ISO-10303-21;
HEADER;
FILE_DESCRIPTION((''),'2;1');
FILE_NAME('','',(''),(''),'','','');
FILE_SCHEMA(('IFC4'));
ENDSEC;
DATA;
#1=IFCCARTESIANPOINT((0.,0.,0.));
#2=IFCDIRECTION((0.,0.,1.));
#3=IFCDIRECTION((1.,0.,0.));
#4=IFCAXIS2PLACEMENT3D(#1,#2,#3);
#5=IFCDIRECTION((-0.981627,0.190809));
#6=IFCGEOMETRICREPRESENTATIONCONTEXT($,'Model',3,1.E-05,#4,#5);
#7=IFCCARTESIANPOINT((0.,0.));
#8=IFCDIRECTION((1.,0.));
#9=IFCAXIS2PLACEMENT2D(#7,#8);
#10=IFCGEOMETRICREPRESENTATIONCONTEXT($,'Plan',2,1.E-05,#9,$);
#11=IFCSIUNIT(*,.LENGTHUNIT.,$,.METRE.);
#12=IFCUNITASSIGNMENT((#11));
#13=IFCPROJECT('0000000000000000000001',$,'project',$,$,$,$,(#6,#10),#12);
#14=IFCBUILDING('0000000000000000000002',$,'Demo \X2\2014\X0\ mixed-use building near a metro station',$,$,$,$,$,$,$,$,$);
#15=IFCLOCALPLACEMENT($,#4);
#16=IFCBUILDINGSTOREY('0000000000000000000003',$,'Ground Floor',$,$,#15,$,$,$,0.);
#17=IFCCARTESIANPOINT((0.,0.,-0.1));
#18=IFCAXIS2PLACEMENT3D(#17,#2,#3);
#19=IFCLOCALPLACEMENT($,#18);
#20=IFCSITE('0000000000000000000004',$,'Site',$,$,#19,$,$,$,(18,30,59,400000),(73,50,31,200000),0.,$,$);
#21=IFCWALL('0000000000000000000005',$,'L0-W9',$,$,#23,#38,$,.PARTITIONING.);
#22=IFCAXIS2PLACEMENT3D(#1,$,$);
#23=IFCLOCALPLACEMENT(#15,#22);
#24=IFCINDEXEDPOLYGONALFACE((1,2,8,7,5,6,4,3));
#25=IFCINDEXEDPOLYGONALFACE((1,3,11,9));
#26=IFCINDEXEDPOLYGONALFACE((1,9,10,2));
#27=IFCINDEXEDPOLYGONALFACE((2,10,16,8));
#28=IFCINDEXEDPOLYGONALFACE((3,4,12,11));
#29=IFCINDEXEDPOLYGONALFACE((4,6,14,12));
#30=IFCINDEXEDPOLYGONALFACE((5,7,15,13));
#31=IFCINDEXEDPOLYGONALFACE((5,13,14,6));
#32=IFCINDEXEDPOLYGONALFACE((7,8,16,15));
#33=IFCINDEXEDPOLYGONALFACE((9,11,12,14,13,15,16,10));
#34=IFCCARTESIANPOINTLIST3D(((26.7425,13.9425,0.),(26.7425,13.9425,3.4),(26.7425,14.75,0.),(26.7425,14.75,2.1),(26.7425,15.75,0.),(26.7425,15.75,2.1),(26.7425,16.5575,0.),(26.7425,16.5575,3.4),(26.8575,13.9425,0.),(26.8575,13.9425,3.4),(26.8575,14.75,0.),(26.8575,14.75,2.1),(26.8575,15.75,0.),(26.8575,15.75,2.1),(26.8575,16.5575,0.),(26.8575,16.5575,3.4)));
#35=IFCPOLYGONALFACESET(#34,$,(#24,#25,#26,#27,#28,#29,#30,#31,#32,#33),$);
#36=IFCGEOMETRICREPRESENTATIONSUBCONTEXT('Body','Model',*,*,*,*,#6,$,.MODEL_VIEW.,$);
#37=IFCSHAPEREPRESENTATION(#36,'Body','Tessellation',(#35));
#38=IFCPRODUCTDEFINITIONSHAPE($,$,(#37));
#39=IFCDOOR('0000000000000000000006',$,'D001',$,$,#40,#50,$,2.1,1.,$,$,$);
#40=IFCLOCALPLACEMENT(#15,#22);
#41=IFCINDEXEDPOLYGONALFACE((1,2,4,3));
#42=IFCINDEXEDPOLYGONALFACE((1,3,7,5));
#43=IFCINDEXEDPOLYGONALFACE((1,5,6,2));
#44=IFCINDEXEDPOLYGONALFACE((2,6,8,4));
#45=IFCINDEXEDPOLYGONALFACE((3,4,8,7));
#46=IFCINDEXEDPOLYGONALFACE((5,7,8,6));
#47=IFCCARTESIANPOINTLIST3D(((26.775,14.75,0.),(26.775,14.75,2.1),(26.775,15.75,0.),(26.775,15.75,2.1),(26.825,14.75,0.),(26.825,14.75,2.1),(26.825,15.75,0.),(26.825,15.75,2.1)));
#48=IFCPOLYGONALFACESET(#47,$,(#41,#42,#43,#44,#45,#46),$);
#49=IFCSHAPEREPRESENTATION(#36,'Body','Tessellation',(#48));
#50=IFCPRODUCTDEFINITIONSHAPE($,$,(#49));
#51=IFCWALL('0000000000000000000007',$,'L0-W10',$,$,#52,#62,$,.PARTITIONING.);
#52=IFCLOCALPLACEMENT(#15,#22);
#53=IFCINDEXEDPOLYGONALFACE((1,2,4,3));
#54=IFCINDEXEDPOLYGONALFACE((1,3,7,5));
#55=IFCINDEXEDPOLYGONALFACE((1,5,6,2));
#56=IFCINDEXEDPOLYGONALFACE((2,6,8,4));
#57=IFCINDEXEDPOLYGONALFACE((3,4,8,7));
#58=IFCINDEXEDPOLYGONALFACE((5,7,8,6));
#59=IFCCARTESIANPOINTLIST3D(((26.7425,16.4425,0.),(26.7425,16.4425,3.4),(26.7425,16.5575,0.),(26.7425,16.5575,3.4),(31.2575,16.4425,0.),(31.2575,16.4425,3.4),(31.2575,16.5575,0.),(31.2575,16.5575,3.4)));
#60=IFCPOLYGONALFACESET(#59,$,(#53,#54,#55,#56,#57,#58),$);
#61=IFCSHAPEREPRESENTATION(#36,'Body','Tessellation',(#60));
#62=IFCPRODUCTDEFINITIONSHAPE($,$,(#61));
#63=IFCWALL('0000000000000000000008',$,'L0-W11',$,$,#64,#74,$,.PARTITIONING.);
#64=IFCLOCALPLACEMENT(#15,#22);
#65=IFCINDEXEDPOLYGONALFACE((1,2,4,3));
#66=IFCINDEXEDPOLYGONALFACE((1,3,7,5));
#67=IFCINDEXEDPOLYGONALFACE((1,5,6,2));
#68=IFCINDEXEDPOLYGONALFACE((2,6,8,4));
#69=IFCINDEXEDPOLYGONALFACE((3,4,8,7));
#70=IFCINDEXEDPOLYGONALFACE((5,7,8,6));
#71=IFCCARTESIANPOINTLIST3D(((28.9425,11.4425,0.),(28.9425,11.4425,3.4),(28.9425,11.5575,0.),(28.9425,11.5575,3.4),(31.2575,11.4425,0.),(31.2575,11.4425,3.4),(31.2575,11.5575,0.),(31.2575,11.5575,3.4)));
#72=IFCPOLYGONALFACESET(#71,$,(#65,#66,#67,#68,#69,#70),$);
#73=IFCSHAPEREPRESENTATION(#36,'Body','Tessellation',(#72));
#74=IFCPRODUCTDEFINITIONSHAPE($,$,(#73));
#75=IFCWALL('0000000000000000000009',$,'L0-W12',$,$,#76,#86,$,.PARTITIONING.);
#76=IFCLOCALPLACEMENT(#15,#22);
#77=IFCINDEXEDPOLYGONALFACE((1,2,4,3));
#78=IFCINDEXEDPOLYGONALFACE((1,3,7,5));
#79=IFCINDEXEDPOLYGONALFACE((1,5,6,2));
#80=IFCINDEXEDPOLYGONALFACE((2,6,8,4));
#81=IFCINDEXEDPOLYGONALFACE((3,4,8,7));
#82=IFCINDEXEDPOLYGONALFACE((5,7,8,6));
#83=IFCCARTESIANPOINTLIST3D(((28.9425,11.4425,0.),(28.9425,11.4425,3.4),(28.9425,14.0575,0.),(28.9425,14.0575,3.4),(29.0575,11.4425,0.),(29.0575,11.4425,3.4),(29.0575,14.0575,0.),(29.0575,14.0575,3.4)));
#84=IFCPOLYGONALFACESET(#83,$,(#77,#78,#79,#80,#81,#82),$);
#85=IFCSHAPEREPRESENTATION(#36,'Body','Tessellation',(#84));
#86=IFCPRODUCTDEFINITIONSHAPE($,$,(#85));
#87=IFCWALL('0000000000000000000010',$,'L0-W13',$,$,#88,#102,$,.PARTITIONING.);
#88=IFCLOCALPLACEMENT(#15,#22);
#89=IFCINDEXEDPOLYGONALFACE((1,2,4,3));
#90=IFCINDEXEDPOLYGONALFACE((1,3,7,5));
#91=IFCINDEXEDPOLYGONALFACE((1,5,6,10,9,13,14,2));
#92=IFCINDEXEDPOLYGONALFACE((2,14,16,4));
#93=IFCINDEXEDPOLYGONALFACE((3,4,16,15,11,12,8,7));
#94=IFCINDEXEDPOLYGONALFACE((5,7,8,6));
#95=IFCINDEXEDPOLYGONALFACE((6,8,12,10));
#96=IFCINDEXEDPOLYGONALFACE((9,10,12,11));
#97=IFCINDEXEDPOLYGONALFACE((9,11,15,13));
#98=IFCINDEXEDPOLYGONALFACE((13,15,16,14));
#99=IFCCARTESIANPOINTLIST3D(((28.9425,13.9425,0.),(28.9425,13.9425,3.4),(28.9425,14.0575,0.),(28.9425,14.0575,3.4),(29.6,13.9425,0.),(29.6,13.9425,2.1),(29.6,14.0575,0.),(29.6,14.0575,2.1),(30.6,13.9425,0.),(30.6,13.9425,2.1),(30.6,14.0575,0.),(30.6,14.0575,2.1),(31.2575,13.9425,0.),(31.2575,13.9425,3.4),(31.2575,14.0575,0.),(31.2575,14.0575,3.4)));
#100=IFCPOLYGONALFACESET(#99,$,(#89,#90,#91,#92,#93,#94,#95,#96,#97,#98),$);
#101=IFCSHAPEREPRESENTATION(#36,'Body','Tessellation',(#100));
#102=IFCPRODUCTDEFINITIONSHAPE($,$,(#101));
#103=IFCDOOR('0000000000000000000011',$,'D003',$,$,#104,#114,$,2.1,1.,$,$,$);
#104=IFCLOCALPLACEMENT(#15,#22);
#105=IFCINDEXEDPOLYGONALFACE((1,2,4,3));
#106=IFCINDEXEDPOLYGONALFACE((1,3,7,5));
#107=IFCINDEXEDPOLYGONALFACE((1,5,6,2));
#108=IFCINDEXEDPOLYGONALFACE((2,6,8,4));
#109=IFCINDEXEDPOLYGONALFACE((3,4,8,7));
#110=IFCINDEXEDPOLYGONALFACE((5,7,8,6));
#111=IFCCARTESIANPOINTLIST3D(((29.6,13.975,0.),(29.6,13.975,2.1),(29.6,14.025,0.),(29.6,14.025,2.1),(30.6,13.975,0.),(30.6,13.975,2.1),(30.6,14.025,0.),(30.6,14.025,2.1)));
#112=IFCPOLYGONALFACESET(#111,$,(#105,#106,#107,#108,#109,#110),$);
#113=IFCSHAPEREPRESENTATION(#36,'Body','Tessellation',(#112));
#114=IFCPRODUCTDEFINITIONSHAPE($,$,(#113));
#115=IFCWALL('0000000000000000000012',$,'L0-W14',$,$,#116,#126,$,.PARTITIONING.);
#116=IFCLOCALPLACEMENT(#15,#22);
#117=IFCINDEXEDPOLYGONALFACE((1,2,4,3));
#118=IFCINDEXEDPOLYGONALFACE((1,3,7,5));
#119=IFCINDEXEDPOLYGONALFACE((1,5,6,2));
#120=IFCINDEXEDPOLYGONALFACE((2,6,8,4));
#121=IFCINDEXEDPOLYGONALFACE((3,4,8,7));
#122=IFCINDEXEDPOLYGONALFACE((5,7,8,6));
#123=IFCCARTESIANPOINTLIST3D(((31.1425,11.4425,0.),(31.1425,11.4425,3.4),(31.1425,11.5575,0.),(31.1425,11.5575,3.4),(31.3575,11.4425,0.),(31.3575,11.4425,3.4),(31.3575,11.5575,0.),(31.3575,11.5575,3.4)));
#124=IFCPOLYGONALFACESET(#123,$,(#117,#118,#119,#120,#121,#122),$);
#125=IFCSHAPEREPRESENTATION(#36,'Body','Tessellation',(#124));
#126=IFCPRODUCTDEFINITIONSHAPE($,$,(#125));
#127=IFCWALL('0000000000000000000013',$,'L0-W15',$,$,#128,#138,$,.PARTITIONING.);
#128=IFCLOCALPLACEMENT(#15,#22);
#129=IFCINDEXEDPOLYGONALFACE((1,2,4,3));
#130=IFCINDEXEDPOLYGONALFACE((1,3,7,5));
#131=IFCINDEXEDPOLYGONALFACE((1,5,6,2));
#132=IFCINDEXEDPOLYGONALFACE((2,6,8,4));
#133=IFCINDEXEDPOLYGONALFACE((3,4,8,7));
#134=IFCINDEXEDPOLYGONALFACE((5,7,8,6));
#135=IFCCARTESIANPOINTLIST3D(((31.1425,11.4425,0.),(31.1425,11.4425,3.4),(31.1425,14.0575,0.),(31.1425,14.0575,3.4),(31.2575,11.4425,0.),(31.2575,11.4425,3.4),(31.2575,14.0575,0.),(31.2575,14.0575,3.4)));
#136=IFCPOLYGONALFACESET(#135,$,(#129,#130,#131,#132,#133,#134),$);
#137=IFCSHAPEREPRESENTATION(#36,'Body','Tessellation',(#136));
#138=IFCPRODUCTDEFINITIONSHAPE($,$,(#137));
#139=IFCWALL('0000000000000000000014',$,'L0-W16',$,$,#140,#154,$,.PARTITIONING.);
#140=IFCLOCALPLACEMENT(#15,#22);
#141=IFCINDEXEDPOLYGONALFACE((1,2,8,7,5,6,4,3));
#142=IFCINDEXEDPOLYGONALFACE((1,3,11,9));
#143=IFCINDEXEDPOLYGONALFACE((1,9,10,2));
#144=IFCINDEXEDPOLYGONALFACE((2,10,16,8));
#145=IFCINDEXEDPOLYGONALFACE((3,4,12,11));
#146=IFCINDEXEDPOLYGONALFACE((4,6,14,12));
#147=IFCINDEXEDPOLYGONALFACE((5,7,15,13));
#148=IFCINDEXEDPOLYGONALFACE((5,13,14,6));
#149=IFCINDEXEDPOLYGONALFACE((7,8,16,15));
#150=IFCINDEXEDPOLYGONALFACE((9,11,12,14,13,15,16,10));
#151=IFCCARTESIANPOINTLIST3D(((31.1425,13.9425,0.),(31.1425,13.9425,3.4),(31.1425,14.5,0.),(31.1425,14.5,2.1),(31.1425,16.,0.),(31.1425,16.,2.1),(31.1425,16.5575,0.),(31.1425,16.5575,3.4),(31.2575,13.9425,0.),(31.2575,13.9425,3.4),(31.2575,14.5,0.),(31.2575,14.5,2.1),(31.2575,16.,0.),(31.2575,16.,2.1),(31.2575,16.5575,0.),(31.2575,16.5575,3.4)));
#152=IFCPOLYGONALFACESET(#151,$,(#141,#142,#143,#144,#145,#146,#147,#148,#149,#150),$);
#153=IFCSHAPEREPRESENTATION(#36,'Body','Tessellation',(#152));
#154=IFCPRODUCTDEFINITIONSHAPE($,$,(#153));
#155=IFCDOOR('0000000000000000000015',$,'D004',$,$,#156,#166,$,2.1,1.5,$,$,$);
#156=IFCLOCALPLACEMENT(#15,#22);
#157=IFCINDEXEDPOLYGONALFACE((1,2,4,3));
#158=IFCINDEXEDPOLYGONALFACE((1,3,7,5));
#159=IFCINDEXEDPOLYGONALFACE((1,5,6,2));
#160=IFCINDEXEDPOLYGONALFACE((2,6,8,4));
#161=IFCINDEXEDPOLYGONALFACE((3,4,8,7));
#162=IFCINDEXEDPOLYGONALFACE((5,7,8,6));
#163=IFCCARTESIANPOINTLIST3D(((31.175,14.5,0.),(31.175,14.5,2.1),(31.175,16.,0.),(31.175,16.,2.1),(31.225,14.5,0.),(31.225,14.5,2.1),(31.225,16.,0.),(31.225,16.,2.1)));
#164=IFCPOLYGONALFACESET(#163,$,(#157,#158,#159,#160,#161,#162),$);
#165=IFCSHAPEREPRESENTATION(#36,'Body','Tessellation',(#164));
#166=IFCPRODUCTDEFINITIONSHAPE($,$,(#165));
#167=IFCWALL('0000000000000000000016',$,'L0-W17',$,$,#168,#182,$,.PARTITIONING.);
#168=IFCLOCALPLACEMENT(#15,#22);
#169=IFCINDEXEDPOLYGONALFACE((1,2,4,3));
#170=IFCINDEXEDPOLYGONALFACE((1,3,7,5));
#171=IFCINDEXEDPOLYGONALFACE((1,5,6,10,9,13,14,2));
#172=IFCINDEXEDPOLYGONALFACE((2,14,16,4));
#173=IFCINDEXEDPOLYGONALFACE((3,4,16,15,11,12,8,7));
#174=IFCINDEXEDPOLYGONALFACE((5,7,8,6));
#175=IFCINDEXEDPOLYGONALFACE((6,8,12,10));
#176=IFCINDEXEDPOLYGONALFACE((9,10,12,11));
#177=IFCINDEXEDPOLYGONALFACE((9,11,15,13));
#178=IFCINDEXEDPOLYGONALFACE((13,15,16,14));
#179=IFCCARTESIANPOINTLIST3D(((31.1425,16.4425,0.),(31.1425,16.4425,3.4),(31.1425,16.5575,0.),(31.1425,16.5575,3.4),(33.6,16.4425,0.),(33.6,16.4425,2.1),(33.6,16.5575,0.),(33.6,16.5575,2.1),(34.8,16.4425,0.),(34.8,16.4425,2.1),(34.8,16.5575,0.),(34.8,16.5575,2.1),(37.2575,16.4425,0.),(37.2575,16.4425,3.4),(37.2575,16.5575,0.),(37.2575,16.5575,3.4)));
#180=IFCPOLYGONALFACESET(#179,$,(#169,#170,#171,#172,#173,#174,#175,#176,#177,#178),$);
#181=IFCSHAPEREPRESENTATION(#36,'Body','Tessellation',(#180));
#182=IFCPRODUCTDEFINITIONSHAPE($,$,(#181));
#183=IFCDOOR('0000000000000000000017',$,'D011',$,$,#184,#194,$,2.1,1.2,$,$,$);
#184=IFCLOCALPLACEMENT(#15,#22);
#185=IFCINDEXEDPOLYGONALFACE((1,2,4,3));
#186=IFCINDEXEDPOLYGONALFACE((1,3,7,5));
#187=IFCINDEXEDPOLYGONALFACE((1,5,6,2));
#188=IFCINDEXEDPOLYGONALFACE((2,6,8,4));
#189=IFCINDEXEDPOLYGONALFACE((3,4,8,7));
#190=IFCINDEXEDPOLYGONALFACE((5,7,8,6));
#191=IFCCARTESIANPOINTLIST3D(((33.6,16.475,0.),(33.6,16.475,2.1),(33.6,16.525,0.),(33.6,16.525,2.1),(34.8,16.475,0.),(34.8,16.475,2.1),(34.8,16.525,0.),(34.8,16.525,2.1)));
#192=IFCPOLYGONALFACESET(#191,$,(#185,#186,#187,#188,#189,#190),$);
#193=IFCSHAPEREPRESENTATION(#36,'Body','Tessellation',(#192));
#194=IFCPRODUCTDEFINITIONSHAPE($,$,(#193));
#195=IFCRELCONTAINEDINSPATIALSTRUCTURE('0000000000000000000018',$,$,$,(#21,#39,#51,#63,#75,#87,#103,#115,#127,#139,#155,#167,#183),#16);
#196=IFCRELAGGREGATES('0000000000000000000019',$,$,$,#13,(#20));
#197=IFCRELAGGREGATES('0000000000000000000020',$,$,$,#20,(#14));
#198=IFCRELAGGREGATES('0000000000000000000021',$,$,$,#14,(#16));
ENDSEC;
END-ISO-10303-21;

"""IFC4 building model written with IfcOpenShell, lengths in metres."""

from ifc_helpers import new_model, si_unit, direction, frame, origin_with_axes, origin_2d_with_axis, place, context, subcontext, project, spatial, line, indexed_curve, outline, extrude, element, fill, save


model = new_model("IFC4")

# Units and contexts
model_context = context("Model", 3, precision=1e-05, world=origin_with_axes(), true_north=direction((-0.981627, 0.190809)))
plan_context = context("Plan", 2, precision=1e-05, world=origin_2d_with_axis())
body_context = subcontext(model_context, "Body", "Model", "MODEL_VIEW")
ifc_project = project(units=[si_unit("LENGTHUNIT", "METRE")], contexts=[model_context, plan_context])

# Site, building, storey
site_placement = place(None, frame((0.0, 0.0, -0.1), z_axis=(0.0, 0.0, 1.0), x_axis=(1.0, 0.0, 0.0)))
site = spatial("IfcSite", under=ifc_project, at=site_placement, Name="Site", RefLatitude=(18, 30, 59, 400000), RefLongitude=(73, 50, 31, 200000), RefElevation=0.0)
building = spatial("IfcBuilding", under=site, Name="Demo — mixed-use building near a metro station")
storey_placement = place(None, origin_with_axes())
storey = spatial("IfcBuildingStorey", under=building, at=storey_placement, Name="Ground Floor", Elevation=0.0)

# Wall, opening, door
wall_1_placement = place(storey_placement, origin_with_axes())
wall_1 = element("IfcWall", 1, at=wall_1_placement, inside=storey, Name="L0-W9", PredefinedType="PARTITIONING", context=body_context, shape_type="SweptSolid", body=[
    extrude(outline(indexed_curve([(26.7425, 13.9425), (26.7425, 16.5575), (26.8575, 16.5575), (26.8575, 13.9425)], segments=[line(1, 2, 3, 4, 1)])), origin_with_axes(), (0.0, 0.0, 1.0), 3.4),
])
opening_1_placement = place(wall_1_placement, origin_with_axes())
opening_1 = element("IfcOpeningElement", 2, at=opening_1_placement, cuts=wall_1, context=body_context, shape_type="SweptSolid", body=[
    extrude(outline(indexed_curve([(26.6925, 14.75), (26.6925, 15.75), (26.9075, 15.75), (26.9075, 14.75)], segments=[line(1, 2, 3, 4, 1)])), origin_with_axes(), (0.0, 0.0, 1.0), 2.1),
])
door_1_placement = place(storey_placement, origin_with_axes())
door_1 = element("IfcDoor", 3, at=door_1_placement, inside=storey, Name="D001", OverallHeight=2.1, OverallWidth=1.0, context=body_context, shape_type="SweptSolid", body=[
    extrude(outline(indexed_curve([(26.775, 14.75), (26.775, 15.75), (26.825, 15.75), (26.825, 14.75)], segments=[line(1, 2, 3, 4, 1)])), origin_with_axes(), (0.0, 0.0, 1.0), 2.1),
])
fill(opening_1, door_1)

# Walls
wall_2_placement = place(storey_placement, origin_with_axes())
element("IfcWall", 4, at=wall_2_placement, inside=storey, Name="L0-W10", PredefinedType="PARTITIONING", context=body_context, shape_type="SweptSolid", body=[
    extrude(outline(indexed_curve([(31.2575, 16.4425), (26.7425, 16.4425), (26.7425, 16.5575), (31.2575, 16.5575)], segments=[line(1, 2, 3, 4, 1)])), origin_with_axes(), (0.0, 0.0, 1.0), 3.4),
])
wall_3_placement = place(storey_placement, origin_with_axes())
element("IfcWall", 5, at=wall_3_placement, inside=storey, Name="L0-W11", PredefinedType="PARTITIONING", context=body_context, shape_type="SweptSolid", body=[
    extrude(outline(indexed_curve([(31.2575, 11.4425), (28.9425, 11.4425), (28.9425, 11.5575), (31.2575, 11.5575)], segments=[line(1, 2, 3, 4, 1)])), origin_with_axes(), (0.0, 0.0, 1.0), 3.4),
])
wall_4_placement = place(storey_placement, origin_with_axes())
element("IfcWall", 6, at=wall_4_placement, inside=storey, Name="L0-W12", PredefinedType="PARTITIONING", context=body_context, shape_type="SweptSolid", body=[
    extrude(outline(indexed_curve([(28.9425, 11.4425), (28.9425, 14.0575), (29.0575, 14.0575), (29.0575, 11.4425)], segments=[line(1, 2, 3, 4, 1)])), origin_with_axes(), (0.0, 0.0, 1.0), 3.4),
])

# Wall, opening, door
wall_5_placement = place(storey_placement, origin_with_axes())
wall_5 = element("IfcWall", 7, at=wall_5_placement, inside=storey, Name="L0-W13", PredefinedType="PARTITIONING", context=body_context, shape_type="SweptSolid", body=[
    extrude(outline(indexed_curve([(31.2575, 13.9425), (28.9425, 13.9425), (28.9425, 14.0575), (31.2575, 14.0575)], segments=[line(1, 2, 3, 4, 1)])), origin_with_axes(), (0.0, 0.0, 1.0), 3.4),
])
opening_2_placement = place(wall_5_placement, origin_with_axes())
opening_2 = element("IfcOpeningElement", 8, at=opening_2_placement, cuts=wall_5, context=body_context, shape_type="SweptSolid", body=[
    extrude(outline(indexed_curve([(30.6, 13.8925), (29.6, 13.8925), (29.6, 14.1075), (30.6, 14.1075)], segments=[line(1, 2, 3, 4, 1)])), origin_with_axes(), (0.0, 0.0, 1.0), 2.1),
])
door_2_placement = place(storey_placement, origin_with_axes())
door_2 = element("IfcDoor", 9, at=door_2_placement, inside=storey, Name="D003", OverallHeight=2.1, OverallWidth=1.0, context=body_context, shape_type="SweptSolid", body=[
    extrude(outline(indexed_curve([(30.6, 13.975), (29.6, 13.975), (29.6, 14.025), (30.6, 14.025)], segments=[line(1, 2, 3, 4, 1)])), origin_with_axes(), (0.0, 0.0, 1.0), 2.1),
])
fill(opening_2, door_2)

# Walls
wall_6_placement = place(storey_placement, origin_with_axes())
element("IfcWall", 10, at=wall_6_placement, inside=storey, Name="L0-W14", PredefinedType="PARTITIONING", context=body_context, shape_type="SweptSolid", body=[
    extrude(outline(indexed_curve([(31.3575, 11.4425), (31.1425, 11.4425), (31.1425, 11.5575), (31.3575, 11.5575)], segments=[line(1, 2, 3, 4, 1)])), origin_with_axes(), (0.0, 0.0, 1.0), 3.4),
])
wall_7_placement = place(storey_placement, origin_with_axes())
element("IfcWall", 11, at=wall_7_placement, inside=storey, Name="L0-W15", PredefinedType="PARTITIONING", context=body_context, shape_type="SweptSolid", body=[
    extrude(outline(indexed_curve([(31.1425, 11.4425), (31.1425, 14.0575), (31.2575, 14.0575), (31.2575, 11.4425)], segments=[line(1, 2, 3, 4, 1)])), origin_with_axes(), (0.0, 0.0, 1.0), 3.4),
])

# Walls, openings, doors
wall_8_placement = place(storey_placement, origin_with_axes())
wall_8 = element("IfcWall", 12, at=wall_8_placement, inside=storey, Name="L0-W16", PredefinedType="PARTITIONING", context=body_context, shape_type="SweptSolid", body=[
    extrude(outline(indexed_curve([(31.1425, 13.9425), (31.1425, 16.5575), (31.2575, 16.5575), (31.2575, 13.9425)], segments=[line(1, 2, 3, 4, 1)])), origin_with_axes(), (0.0, 0.0, 1.0), 3.4),
])
opening_3_placement = place(wall_8_placement, origin_with_axes())
opening_3 = element("IfcOpeningElement", 13, at=opening_3_placement, cuts=wall_8, context=body_context, shape_type="SweptSolid", body=[
    extrude(outline(indexed_curve([(31.0925, 14.5), (31.0925, 16.0), (31.3075, 16.0), (31.3075, 14.5)], segments=[line(1, 2, 3, 4, 1)])), origin_with_axes(), (0.0, 0.0, 1.0), 2.1),
])
door_3_placement = place(storey_placement, origin_with_axes())
door_3 = element("IfcDoor", 14, at=door_3_placement, inside=storey, Name="D004", OverallHeight=2.1, OverallWidth=1.5, context=body_context, shape_type="SweptSolid", body=[
    extrude(outline(indexed_curve([(31.175, 14.5), (31.175, 16.0), (31.225, 16.0), (31.225, 14.5)], segments=[line(1, 2, 3, 4, 1)])), origin_with_axes(), (0.0, 0.0, 1.0), 2.1),
])
fill(opening_3, door_3)
wall_9_placement = place(storey_placement, origin_with_axes())
wall_9 = element("IfcWall", 15, at=wall_9_placement, inside=storey, Name="L0-W17", PredefinedType="PARTITIONING", context=body_context, shape_type="SweptSolid", body=[
    extrude(outline(indexed_curve([(37.2575, 16.4425), (31.1425, 16.4425), (31.1425, 16.5575), (37.2575, 16.5575)], segments=[line(1, 2, 3, 4, 1)])), origin_with_axes(), (0.0, 0.0, 1.0), 3.4),
])
opening_4_placement = place(wall_9_placement, origin_with_axes())
opening_4 = element("IfcOpeningElement", 16, at=opening_4_placement, cuts=wall_9, context=body_context, shape_type="SweptSolid", body=[
    extrude(outline(indexed_curve([(34.8, 16.3925), (33.6, 16.3925), (33.6, 16.6075), (34.8, 16.6075)], segments=[line(1, 2, 3, 4, 1)])), origin_with_axes(), (0.0, 0.0, 1.0), 2.1),
])
door_4_placement = place(storey_placement, origin_with_axes())
door_4 = element("IfcDoor", 17, at=door_4_placement, inside=storey, Name="D011", OverallHeight=2.1, OverallWidth=1.2, context=body_context, shape_type="SweptSolid", body=[
    extrude(outline(indexed_curve([(34.8, 16.475), (33.6, 16.475), (33.6, 16.525), (34.8, 16.525)], segments=[line(1, 2, 3, 4, 1)])), origin_with_axes(), (0.0, 0.0, 1.0), 2.1),
])
fill(opening_4, door_4)

save(model, "model.ifc")
